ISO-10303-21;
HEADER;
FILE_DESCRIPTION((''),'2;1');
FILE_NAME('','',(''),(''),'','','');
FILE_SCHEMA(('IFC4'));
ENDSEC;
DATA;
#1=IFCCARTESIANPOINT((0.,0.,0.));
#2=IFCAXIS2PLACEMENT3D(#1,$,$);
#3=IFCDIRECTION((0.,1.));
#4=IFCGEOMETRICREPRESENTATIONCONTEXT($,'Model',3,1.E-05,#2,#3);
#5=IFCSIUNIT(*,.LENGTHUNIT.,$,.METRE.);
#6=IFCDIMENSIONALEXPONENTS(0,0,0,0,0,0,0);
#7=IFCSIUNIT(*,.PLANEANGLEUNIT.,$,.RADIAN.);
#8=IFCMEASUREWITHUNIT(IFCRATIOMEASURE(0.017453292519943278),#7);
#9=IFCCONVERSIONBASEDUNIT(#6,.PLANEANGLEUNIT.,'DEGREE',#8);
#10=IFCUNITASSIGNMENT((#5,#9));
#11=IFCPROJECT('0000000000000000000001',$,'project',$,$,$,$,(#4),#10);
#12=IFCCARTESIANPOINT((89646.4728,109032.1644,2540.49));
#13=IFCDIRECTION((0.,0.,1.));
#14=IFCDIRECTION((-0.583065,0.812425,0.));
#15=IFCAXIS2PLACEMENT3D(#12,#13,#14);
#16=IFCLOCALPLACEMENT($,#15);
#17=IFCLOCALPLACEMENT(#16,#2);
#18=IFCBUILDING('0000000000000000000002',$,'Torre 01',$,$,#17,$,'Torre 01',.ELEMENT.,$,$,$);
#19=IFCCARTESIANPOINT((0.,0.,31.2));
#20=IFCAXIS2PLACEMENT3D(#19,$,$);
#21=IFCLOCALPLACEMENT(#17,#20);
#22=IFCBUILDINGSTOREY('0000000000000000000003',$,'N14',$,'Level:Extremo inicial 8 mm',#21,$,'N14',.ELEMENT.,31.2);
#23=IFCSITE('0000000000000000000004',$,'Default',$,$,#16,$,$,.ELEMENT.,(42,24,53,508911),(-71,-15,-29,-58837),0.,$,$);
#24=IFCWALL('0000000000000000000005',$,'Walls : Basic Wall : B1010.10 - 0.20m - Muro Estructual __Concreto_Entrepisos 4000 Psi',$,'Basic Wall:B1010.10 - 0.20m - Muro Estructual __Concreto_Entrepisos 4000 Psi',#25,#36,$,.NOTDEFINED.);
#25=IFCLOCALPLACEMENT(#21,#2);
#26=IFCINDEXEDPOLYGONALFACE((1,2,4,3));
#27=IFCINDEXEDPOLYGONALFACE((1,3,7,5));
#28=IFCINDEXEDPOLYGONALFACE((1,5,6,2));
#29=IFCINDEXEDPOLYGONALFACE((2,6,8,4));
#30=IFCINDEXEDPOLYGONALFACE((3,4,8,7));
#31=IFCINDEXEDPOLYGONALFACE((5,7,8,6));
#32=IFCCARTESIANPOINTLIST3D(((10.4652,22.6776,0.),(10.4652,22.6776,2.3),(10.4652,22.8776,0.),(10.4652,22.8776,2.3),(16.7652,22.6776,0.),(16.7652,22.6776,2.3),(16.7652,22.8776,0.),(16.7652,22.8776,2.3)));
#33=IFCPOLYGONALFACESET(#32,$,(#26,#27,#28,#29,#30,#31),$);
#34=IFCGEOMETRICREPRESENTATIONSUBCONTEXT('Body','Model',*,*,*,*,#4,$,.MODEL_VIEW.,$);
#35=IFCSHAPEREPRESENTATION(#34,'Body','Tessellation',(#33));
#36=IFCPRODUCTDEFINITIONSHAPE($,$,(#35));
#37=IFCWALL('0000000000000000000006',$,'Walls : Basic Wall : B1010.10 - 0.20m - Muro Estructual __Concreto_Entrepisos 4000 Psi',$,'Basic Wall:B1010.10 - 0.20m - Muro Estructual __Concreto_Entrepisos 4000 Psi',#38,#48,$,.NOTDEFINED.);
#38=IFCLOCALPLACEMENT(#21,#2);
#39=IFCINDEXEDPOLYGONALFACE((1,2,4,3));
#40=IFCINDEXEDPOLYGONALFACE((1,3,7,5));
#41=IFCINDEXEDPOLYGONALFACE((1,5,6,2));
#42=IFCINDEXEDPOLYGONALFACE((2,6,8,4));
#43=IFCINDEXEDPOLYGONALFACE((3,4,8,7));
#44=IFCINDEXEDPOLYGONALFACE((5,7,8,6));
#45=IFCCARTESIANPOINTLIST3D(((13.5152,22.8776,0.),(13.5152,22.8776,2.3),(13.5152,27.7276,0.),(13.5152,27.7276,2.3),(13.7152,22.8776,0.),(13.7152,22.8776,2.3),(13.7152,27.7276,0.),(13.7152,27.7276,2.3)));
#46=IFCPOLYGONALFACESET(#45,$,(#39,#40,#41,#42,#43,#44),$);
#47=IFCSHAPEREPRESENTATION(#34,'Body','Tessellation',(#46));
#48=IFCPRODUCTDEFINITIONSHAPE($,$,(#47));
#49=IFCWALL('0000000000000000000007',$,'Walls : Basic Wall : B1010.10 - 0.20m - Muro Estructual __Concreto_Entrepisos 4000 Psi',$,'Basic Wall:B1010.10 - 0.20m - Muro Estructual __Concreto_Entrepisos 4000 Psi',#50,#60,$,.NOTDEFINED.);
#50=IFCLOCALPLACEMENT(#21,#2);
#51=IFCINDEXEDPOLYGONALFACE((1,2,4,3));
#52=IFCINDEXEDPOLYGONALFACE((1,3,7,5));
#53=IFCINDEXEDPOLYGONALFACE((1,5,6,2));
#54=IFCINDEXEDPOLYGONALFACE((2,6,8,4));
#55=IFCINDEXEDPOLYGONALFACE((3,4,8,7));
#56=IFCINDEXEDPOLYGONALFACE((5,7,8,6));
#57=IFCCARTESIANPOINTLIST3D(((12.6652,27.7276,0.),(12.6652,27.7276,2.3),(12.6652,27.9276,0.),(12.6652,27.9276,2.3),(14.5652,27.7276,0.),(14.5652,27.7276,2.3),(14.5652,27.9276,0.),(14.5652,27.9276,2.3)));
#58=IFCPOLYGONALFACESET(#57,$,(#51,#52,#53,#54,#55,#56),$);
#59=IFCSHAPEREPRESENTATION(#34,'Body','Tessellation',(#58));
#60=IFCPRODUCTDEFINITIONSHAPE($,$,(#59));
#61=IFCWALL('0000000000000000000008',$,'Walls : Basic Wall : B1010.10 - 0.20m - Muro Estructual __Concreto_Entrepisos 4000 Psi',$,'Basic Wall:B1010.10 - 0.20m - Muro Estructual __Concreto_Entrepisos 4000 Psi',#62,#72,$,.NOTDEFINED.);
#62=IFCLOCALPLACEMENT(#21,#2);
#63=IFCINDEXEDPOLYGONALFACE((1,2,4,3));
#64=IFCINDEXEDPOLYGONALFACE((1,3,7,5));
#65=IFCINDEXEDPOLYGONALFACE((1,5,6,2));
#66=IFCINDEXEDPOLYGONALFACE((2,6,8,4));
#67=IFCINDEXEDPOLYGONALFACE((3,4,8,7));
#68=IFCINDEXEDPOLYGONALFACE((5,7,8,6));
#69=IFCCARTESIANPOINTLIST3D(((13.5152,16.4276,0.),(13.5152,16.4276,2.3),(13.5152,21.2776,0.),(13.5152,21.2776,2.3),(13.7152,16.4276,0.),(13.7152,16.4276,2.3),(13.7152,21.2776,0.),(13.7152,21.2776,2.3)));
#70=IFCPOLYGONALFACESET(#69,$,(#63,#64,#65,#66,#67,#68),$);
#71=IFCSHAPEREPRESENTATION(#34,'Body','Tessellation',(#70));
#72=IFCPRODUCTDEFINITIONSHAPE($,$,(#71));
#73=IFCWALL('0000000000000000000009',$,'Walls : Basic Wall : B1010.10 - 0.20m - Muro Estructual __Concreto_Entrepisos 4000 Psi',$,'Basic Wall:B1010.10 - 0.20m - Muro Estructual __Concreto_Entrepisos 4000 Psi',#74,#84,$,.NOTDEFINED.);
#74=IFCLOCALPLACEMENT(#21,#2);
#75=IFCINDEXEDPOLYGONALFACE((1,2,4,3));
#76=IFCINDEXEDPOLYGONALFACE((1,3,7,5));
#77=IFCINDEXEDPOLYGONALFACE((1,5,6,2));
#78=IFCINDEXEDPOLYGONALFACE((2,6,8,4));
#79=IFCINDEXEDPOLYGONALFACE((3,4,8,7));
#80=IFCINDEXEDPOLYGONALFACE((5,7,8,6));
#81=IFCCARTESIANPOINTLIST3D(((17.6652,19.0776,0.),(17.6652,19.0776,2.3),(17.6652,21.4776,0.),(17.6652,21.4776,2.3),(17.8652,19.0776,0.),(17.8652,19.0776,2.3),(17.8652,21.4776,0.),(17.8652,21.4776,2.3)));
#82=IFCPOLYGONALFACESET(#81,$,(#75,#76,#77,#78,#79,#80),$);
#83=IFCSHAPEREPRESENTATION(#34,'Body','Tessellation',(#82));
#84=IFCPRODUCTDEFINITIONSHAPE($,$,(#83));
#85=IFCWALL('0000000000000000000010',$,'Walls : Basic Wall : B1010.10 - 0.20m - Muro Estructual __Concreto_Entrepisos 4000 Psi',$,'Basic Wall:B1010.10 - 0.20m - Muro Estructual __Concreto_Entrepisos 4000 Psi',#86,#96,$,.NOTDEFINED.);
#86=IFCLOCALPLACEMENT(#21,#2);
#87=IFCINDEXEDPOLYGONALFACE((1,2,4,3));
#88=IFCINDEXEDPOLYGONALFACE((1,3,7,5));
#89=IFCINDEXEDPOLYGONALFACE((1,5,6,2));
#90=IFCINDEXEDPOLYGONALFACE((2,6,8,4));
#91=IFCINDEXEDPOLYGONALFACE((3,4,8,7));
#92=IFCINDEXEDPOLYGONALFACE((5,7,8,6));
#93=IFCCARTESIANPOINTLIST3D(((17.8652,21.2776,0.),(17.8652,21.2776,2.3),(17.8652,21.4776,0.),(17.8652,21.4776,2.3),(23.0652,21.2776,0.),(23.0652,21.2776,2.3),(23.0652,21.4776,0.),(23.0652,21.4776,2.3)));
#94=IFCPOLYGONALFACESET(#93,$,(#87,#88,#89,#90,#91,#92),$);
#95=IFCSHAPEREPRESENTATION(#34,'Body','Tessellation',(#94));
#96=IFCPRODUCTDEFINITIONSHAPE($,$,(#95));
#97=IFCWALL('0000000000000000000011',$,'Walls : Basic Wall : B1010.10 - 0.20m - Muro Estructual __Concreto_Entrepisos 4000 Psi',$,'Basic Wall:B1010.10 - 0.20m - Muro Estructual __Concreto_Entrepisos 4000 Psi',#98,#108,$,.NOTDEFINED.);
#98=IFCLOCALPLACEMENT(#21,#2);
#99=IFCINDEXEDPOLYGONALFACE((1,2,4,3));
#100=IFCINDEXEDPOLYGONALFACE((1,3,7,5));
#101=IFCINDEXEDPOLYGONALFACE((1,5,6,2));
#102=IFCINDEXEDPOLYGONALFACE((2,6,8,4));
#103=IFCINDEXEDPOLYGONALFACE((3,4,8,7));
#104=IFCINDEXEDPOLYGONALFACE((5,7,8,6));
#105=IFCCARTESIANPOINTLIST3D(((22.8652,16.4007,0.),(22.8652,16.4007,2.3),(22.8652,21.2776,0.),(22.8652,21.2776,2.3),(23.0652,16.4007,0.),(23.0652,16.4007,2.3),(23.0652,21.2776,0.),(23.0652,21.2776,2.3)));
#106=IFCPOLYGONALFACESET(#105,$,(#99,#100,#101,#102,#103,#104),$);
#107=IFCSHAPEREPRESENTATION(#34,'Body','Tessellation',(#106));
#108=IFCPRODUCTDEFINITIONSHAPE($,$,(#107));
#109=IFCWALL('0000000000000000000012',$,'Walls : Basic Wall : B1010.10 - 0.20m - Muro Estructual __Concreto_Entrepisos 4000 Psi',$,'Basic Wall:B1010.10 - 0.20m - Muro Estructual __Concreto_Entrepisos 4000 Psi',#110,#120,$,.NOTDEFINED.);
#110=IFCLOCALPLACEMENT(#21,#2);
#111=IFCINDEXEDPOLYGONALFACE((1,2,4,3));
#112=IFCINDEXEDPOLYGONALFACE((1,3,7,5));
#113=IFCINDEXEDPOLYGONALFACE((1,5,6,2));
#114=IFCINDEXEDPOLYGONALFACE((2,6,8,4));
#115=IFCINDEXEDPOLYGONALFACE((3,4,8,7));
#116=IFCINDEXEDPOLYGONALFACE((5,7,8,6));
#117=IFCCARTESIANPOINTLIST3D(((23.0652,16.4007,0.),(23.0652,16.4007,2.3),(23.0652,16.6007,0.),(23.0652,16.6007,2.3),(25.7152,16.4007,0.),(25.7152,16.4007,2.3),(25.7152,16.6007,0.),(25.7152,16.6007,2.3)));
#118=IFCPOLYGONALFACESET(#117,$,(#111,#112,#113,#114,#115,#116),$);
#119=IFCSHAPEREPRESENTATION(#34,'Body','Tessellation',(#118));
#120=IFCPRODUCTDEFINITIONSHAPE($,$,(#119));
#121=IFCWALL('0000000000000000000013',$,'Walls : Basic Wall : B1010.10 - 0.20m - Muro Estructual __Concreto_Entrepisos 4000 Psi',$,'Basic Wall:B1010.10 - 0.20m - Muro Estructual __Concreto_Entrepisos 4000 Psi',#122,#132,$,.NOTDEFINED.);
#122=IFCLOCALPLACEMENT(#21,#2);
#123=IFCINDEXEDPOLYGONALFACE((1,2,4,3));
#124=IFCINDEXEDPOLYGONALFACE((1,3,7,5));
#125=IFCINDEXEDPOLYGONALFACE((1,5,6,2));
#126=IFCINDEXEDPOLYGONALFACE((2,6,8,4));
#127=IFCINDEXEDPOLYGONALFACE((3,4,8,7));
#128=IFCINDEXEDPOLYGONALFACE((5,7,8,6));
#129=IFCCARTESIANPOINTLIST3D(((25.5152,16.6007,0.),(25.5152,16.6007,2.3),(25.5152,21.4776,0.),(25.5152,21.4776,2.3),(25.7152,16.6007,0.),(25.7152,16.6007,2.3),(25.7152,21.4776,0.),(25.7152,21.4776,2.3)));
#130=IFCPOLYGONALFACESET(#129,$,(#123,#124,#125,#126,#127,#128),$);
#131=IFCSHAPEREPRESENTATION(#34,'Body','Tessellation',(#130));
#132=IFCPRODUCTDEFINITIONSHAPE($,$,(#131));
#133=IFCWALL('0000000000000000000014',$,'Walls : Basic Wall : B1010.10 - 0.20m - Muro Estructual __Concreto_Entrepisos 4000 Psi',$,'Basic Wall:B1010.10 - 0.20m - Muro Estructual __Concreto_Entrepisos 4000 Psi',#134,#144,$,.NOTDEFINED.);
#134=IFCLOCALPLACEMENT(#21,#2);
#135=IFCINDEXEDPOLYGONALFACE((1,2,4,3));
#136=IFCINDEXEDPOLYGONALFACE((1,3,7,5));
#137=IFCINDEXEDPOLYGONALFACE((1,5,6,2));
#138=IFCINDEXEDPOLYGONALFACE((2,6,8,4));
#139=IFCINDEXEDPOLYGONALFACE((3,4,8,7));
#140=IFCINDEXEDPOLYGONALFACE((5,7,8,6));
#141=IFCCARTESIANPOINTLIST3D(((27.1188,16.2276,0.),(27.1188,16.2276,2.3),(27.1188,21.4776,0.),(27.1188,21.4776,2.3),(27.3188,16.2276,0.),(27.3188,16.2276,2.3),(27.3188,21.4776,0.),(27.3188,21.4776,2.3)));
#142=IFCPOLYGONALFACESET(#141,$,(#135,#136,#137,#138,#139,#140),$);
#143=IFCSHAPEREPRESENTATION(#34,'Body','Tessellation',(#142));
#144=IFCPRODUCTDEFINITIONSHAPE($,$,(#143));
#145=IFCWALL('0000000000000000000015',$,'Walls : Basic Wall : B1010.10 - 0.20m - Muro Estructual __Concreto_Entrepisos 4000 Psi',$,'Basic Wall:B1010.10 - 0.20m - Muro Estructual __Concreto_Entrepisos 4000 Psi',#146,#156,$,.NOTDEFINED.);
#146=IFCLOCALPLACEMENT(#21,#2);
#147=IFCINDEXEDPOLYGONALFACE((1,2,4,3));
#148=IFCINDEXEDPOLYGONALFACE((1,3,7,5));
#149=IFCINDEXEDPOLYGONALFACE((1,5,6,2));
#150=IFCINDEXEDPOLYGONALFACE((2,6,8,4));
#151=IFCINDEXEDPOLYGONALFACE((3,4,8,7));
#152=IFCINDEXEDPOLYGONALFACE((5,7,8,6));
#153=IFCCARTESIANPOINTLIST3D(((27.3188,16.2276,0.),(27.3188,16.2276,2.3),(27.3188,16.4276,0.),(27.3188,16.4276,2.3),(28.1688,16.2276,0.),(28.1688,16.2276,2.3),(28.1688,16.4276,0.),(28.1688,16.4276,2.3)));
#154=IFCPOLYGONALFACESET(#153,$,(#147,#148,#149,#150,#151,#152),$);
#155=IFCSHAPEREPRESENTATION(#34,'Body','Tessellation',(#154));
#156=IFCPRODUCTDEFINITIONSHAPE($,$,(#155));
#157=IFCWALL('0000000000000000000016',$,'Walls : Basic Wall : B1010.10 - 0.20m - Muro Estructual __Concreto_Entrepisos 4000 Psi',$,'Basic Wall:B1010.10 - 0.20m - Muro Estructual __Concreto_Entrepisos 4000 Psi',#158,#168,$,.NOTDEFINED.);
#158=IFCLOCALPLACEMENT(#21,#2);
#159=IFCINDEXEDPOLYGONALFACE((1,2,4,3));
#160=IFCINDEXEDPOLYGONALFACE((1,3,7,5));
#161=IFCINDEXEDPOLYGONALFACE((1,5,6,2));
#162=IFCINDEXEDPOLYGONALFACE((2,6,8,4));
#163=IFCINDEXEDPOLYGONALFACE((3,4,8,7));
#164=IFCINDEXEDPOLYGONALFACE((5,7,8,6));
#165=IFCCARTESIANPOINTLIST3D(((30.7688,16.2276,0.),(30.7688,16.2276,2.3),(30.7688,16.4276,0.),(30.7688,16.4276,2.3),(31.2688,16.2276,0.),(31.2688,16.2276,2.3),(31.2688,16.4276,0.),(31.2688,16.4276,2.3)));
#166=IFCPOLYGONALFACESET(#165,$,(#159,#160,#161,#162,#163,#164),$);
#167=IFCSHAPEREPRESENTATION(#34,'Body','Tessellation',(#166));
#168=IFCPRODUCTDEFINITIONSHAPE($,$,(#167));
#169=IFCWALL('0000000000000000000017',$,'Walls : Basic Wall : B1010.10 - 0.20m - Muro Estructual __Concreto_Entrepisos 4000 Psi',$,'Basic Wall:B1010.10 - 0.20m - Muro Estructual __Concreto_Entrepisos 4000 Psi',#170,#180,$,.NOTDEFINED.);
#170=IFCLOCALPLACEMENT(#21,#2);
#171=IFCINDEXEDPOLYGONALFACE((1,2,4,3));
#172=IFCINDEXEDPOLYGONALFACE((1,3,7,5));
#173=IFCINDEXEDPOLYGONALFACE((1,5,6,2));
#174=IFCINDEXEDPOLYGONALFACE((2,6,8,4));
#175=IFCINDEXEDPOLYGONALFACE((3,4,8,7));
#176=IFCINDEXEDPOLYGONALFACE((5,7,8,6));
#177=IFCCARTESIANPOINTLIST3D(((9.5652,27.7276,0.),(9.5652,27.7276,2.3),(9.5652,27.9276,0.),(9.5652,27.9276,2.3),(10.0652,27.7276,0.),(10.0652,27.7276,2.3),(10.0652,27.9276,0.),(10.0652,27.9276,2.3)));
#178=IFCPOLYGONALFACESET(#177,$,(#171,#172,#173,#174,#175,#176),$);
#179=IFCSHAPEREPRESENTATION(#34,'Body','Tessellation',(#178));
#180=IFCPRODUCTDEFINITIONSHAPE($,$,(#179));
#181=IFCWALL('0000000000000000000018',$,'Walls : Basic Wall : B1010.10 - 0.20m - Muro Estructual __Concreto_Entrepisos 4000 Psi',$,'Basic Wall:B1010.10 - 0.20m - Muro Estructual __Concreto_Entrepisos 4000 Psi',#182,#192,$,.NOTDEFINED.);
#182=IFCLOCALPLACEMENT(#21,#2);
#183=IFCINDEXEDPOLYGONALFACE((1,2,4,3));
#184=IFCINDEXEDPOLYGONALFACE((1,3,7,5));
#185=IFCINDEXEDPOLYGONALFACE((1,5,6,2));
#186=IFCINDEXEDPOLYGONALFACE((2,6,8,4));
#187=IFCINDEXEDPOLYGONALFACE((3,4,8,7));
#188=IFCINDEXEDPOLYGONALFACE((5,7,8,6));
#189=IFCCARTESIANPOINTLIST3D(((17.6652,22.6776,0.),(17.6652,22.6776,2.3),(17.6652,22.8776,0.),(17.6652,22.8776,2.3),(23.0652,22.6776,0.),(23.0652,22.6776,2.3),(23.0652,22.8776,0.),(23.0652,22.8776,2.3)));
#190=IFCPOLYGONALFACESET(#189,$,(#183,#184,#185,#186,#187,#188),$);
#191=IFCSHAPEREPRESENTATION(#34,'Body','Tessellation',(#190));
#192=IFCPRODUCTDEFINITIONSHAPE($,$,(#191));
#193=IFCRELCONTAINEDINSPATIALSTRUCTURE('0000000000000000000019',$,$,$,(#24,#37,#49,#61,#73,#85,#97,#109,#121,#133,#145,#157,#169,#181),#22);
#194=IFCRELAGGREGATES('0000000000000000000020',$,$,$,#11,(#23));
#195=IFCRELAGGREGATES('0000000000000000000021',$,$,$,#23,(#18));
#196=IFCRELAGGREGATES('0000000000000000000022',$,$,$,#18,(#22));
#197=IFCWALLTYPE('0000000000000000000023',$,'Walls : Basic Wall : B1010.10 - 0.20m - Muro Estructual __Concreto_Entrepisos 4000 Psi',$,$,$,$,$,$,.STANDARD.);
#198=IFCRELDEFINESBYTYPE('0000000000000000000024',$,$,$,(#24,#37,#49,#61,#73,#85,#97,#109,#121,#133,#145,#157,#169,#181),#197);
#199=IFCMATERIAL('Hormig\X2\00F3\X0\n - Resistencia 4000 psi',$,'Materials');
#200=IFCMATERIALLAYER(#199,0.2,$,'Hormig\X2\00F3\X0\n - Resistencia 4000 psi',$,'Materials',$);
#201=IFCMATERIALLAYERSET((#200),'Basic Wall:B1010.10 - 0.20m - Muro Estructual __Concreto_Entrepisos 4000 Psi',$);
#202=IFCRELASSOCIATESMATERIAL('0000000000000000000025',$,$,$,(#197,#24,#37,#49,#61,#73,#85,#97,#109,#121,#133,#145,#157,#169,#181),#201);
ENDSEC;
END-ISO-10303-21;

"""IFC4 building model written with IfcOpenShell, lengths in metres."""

from ifc_helpers import new_model, entity, si_unit, converted_unit, direction, frame, frame_2d, origin, place, context, subcontext, project, spatial, rectangle, extrude, material, layer, layer_set, layer_usage, type_object, element, save


model = new_model("IFC4")

# Units and contexts
model_context = context("Model", 3, precision=1e-05, world=origin(), true_north=direction((0.0, 1.0)))
body_context = subcontext(model_context, "Body", "Model", "MODEL_VIEW")
ifc_project = project(units=[si_unit("LENGTHUNIT", "METRE"), converted_unit("PLANEANGLEUNIT", "DEGREE", entity("IfcRatioMeasure", 0.017453292519943278), si_unit("PLANEANGLEUNIT", "RADIAN"), dimensions=[0, 0, 0, 0, 0, 0, 0])], contexts=[model_context])

# Site, building, storey
site_placement = place(None, frame((89646.4728, 109032.1644, 2540.49), z_axis=(0.0, 0.0, 1.0), x_axis=(-0.583065, 0.812425, 0.0)))
site = spatial("IfcSite", under=ifc_project, at=site_placement, Name="Default", CompositionType="ELEMENT", RefLatitude=(42, 24, 53, 508911), RefLongitude=(-71, -15, -29, -58837), RefElevation=0.0)
building_placement = place(site_placement, origin())
building = spatial("IfcBuilding", under=site, at=building_placement, Name="Torre 01", LongName="Torre 01", CompositionType="ELEMENT")
storey_placement = place(building_placement, frame((0.0, 0.0, 31.2)))
storey = spatial("IfcBuildingStorey", under=building, at=storey_placement, Name="N14", ObjectType="Level:Extremo inicial 8 mm", LongName="N14", CompositionType="ELEMENT", Elevation=31.2)

# Walls
ifc_material = material(Name="Hormigón - Resistencia 4000 psi", Category="Materials")
ifc_layer_1 = layer(ifc_material, 0.2, Name="Hormigón - Resistencia 4000 psi", Category="Materials")
ifc_layer_set_1 = layer_set([ifc_layer_1], Name="Basic Wall:B1010.10 - 0.20m - Muro Estructual __Concreto_Entrepisos 4000 Psi")
ifc_layer_usage_1 = layer_usage(ifc_layer_set_1, "AXIS2", "NEGATIVE", 0.1)
wall_type_1 = type_object("IfcWallType", Name="Walls : Basic Wall : B1010.10 - 0.20m - Muro Estructual __Concreto_Entrepisos 4000 Psi", PredefinedType="STANDARD", material=ifc_layer_set_1)
wall_1_placement = place(storey_placement, frame((10.4652, 22.7776, 0.0)))
element("IfcWall", 1, at=wall_1_placement, inside=storey, type_object=wall_type_1, material=ifc_layer_usage_1, Name="Walls : Basic Wall : B1010.10 - 0.20m - Muro Estructual __Concreto_Entrepisos 4000 Psi", ObjectType="Basic Wall:B1010.10 - 0.20m - Muro Estructual __Concreto_Entrepisos 4000 Psi", PredefinedType="NOTDEFINED", context=body_context, shape_type="SweptSolid", body=[
    extrude(rectangle(XDim=6.3, YDim=0.2, at=frame_2d((3.15, 0.0), x_axis=(-1.0, 0.0))), origin(), (0.0, 0.0, 1.0), 2.3),
])
ifc_layer_usage_2 = layer_usage(ifc_layer_set_1, "AXIS2", "NEGATIVE", 0.1)
wall_2_placement = place(storey_placement, frame((13.6152, 22.8776, 0.0), z_axis=(0.0, 0.0, 1.0), x_axis=(0.0, 1.0, 0.0)))
element("IfcWall", 2, at=wall_2_placement, inside=storey, type_object=wall_type_1, material=ifc_layer_usage_2, Name="Walls : Basic Wall : B1010.10 - 0.20m - Muro Estructual __Concreto_Entrepisos 4000 Psi", ObjectType="Basic Wall:B1010.10 - 0.20m - Muro Estructual __Concreto_Entrepisos 4000 Psi", PredefinedType="NOTDEFINED", context=body_context, shape_type="SweptSolid", body=[
    extrude(rectangle(XDim=4.85, YDim=0.2, at=frame_2d((2.425, 0.0), x_axis=(-1.0, 0.0))), origin(), (0.0, 0.0, 1.0), 2.3),
])
ifc_layer_usage_3 = layer_usage(ifc_layer_set_1, "AXIS2", "NEGATIVE", 0.1)
wall_3_placement = place(storey_placement, frame((12.6652, 27.8276, 0.0)))
element("IfcWall", 3, at=wall_3_placement, inside=storey, type_object=wall_type_1, material=ifc_layer_usage_3, Name="Walls : Basic Wall : B1010.10 - 0.20m - Muro Estructual __Concreto_Entrepisos 4000 Psi", ObjectType="Basic Wall:B1010.10 - 0.20m - Muro Estructual __Concreto_Entrepisos 4000 Psi", PredefinedType="NOTDEFINED", context=body_context, shape_type="SweptSolid", body=[
    extrude(rectangle(XDim=1.9, YDim=0.2, at=frame_2d((0.95, 0.0), x_axis=(-1.0, 0.0))), origin(), (0.0, 0.0, 1.0), 2.3),
])
ifc_layer_usage_4 = layer_usage(ifc_layer_set_1, "AXIS2", "NEGATIVE", 0.1)
wall_4_placement = place(storey_placement, frame((13.6152, 21.2776, 0.0), z_axis=(0.0, 0.0, 1.0), x_axis=(0.0, -1.0, 0.0)))
element("IfcWall", 4, at=wall_4_placement, inside=storey, type_object=wall_type_1, material=ifc_layer_usage_4, Name="Walls : Basic Wall : B1010.10 - 0.20m - Muro Estructual __Concreto_Entrepisos 4000 Psi", ObjectType="Basic Wall:B1010.10 - 0.20m - Muro Estructual __Concreto_Entrepisos 4000 Psi", PredefinedType="NOTDEFINED", context=body_context, shape_type="SweptSolid", body=[
    extrude(rectangle(XDim=4.85, YDim=0.2, at=frame_2d((2.425, 0.0), x_axis=(-1.0, 0.0))), origin(), (0.0, 0.0, 1.0), 2.3),
])
ifc_layer_usage_5 = layer_usage(ifc_layer_set_1, "AXIS2", "NEGATIVE", 0.1)
wall_5_placement = place(storey_placement, frame((17.7652, 19.0776, 0.0), z_axis=(0.0, 0.0, 1.0), x_axis=(0.0, 1.0, 0.0)))
element("IfcWall", 5, at=wall_5_placement, inside=storey, type_object=wall_type_1, material=ifc_layer_usage_5, Name="Walls : Basic Wall : B1010.10 - 0.20m - Muro Estructual __Concreto_Entrepisos 4000 Psi", ObjectType="Basic Wall:B1010.10 - 0.20m - Muro Estructual __Concreto_Entrepisos 4000 Psi", PredefinedType="NOTDEFINED", context=body_context, shape_type="SweptSolid", body=[
    extrude(rectangle(XDim=2.4, YDim=0.2, at=frame_2d((1.2, 0.0), x_axis=(-1.0, 0.0))), origin(), (0.0, 0.0, 1.0), 2.3),
])
ifc_layer_usage_6 = layer_usage(ifc_layer_set_1, "AXIS2", "NEGATIVE", 0.1)
wall_6_placement = place(storey_placement, frame((17.8652, 21.3776, 0.0)))
element("IfcWall", 6, at=wall_6_placement, inside=storey, type_object=wall_type_1, material=ifc_layer_usage_6, Name="Walls : Basic Wall : B1010.10 - 0.20m - Muro Estructual __Concreto_Entrepisos 4000 Psi", ObjectType="Basic Wall:B1010.10 - 0.20m - Muro Estructual __Concreto_Entrepisos 4000 Psi", PredefinedType="NOTDEFINED", context=body_context, shape_type="SweptSolid", body=[
    extrude(rectangle(XDim=5.2, YDim=0.2, at=frame_2d((2.6, 0.0), x_axis=(-1.0, 0.0))), origin(), (0.0, 0.0, 1.0), 2.3),
])
ifc_layer_usage_7 = layer_usage(ifc_layer_set_1, "AXIS2", "NEGATIVE", 0.1)
wall_7_placement = place(storey_placement, frame((22.9652, 21.2776, 0.0), z_axis=(0.0, 0.0, 1.0), x_axis=(0.0, -1.0, 0.0)))
element("IfcWall", 7, at=wall_7_placement, inside=storey, type_object=wall_type_1, material=ifc_layer_usage_7, Name="Walls : Basic Wall : B1010.10 - 0.20m - Muro Estructual __Concreto_Entrepisos 4000 Psi", ObjectType="Basic Wall:B1010.10 - 0.20m - Muro Estructual __Concreto_Entrepisos 4000 Psi", PredefinedType="NOTDEFINED", context=body_context, shape_type="SweptSolid", body=[
    extrude(rectangle(XDim=4.8769, YDim=0.2, at=frame_2d((2.4384, 0.0), x_axis=(-1.0, 0.0))), origin(), (0.0, 0.0, 1.0), 2.3),
])
ifc_layer_usage_8 = layer_usage(ifc_layer_set_1, "AXIS2", "NEGATIVE", 0.1)
wall_8_placement = place(storey_placement, frame((23.0652, 16.5007, 0.0)))
element("IfcWall", 8, at=wall_8_placement, inside=storey, type_object=wall_type_1, material=ifc_layer_usage_8, Name="Walls : Basic Wall : B1010.10 - 0.20m - Muro Estructual __Concreto_Entrepisos 4000 Psi", ObjectType="Basic Wall:B1010.10 - 0.20m - Muro Estructual __Concreto_Entrepisos 4000 Psi", PredefinedType="NOTDEFINED", context=body_context, shape_type="SweptSolid", body=[
    extrude(rectangle(XDim=2.65, YDim=0.2, at=frame_2d((1.325, 0.0), x_axis=(-1.0, 0.0))), origin(), (0.0, 0.0, 1.0), 2.3),
])
ifc_layer_usage_9 = layer_usage(ifc_layer_set_1, "AXIS2", "NEGATIVE", 0.1)
wall_9_placement = place(storey_placement, frame((25.6152, 16.6007, 0.0), z_axis=(0.0, 0.0, 1.0), x_axis=(0.0, 1.0, 0.0)))
element("IfcWall", 9, at=wall_9_placement, inside=storey, type_object=wall_type_1, material=ifc_layer_usage_9, Name="Walls : Basic Wall : B1010.10 - 0.20m - Muro Estructual __Concreto_Entrepisos 4000 Psi", ObjectType="Basic Wall:B1010.10 - 0.20m - Muro Estructual __Concreto_Entrepisos 4000 Psi", PredefinedType="NOTDEFINED", context=body_context, shape_type="SweptSolid", body=[
    extrude(rectangle(XDim=4.8769, YDim=0.2, at=frame_2d((2.4384, 0.0), x_axis=(-1.0, 0.0))), origin(), (0.0, 0.0, 1.0), 2.3),
])
ifc_layer_usage_10 = layer_usage(ifc_layer_set_1, "AXIS2", "NEGATIVE", 0.1)
wall_10_placement = place(storey_placement, frame((27.2188, 16.2276, 0.0), z_axis=(0.0, 0.0, 1.0), x_axis=(0.0, 1.0, 0.0)))
element("IfcWall", 10, at=wall_10_placement, inside=storey, type_object=wall_type_1, material=ifc_layer_usage_10, Name="Walls : Basic Wall : B1010.10 - 0.20m - Muro Estructual __Concreto_Entrepisos 4000 Psi", ObjectType="Basic Wall:B1010.10 - 0.20m - Muro Estructual __Concreto_Entrepisos 4000 Psi", PredefinedType="NOTDEFINED", context=body_context, shape_type="SweptSolid", body=[
    extrude(rectangle(XDim=5.25, YDim=0.2, at=frame_2d((2.625, 0.0), x_axis=(-1.0, 0.0))), origin(), (0.0, 0.0, 1.0), 2.3),
])
ifc_layer_usage_11 = layer_usage(ifc_layer_set_1, "AXIS2", "NEGATIVE", 0.1)
wall_11_placement = place(storey_placement, frame((27.3188, 16.3276, 0.0)))
element("IfcWall", 11, at=wall_11_placement, inside=storey, type_object=wall_type_1, material=ifc_layer_usage_11, Name="Walls : Basic Wall : B1010.10 - 0.20m - Muro Estructual __Concreto_Entrepisos 4000 Psi", ObjectType="Basic Wall:B1010.10 - 0.20m - Muro Estructual __Concreto_Entrepisos 4000 Psi", PredefinedType="NOTDEFINED", context=body_context, shape_type="SweptSolid", body=[
    extrude(rectangle(XDim=0.85, YDim=0.2, at=frame_2d((0.425, 0.0), x_axis=(-1.0, 0.0))), origin(), (0.0, 0.0, 1.0), 2.3),
])
ifc_layer_usage_12 = layer_usage(ifc_layer_set_1, "AXIS2", "NEGATIVE", 0.1)
wall_12_placement = place(storey_placement, frame((30.7688, 16.3276, 0.0)))
element("IfcWall", 12, at=wall_12_placement, inside=storey, type_object=wall_type_1, material=ifc_layer_usage_12, Name="Walls : Basic Wall : B1010.10 - 0.20m - Muro Estructual __Concreto_Entrepisos 4000 Psi", ObjectType="Basic Wall:B1010.10 - 0.20m - Muro Estructual __Concreto_Entrepisos 4000 Psi", PredefinedType="NOTDEFINED", context=body_context, shape_type="SweptSolid", body=[
    extrude(rectangle(XDim=0.5, YDim=0.2, at=frame_2d((0.25, 0.0), x_axis=(-1.0, 0.0))), origin(), (0.0, 0.0, 1.0), 2.3),
])
ifc_layer_usage_13 = layer_usage(ifc_layer_set_1, "AXIS2", "NEGATIVE", 0.1)
wall_13_placement = place(storey_placement, frame((9.5652, 27.8276, 0.0)))
element("IfcWall", 13, at=wall_13_placement, inside=storey, type_object=wall_type_1, material=ifc_layer_usage_13, Name="Walls : Basic Wall : B1010.10 - 0.20m - Muro Estructual __Concreto_Entrepisos 4000 Psi", ObjectType="Basic Wall:B1010.10 - 0.20m - Muro Estructual __Concreto_Entrepisos 4000 Psi", PredefinedType="NOTDEFINED", context=body_context, shape_type="SweptSolid", body=[
    extrude(rectangle(XDim=0.5, YDim=0.2, at=frame_2d((0.25, 0.0), x_axis=(-1.0, 0.0))), origin(), (0.0, 0.0, 1.0), 2.3),
])
ifc_layer_usage_14 = layer_usage(ifc_layer_set_1, "AXIS2", "NEGATIVE", 0.1)
wall_14_placement = place(storey_placement, frame((17.6652, 22.7776, 0.0)))
element("IfcWall", 14, at=wall_14_placement, inside=storey, type_object=wall_type_1, material=ifc_layer_usage_14, Name="Walls : Basic Wall : B1010.10 - 0.20m - Muro Estructual __Concreto_Entrepisos 4000 Psi", ObjectType="Basic Wall:B1010.10 - 0.20m - Muro Estructual __Concreto_Entrepisos 4000 Psi", PredefinedType="NOTDEFINED", context=body_context, shape_type="SweptSolid", body=[
    extrude(rectangle(XDim=5.4, YDim=0.2, at=frame_2d((2.7, 0.0), x_axis=(-1.0, 0.0))), origin(), (0.0, 0.0, 1.0), 2.3),
])

save(model, "model.ifc")
